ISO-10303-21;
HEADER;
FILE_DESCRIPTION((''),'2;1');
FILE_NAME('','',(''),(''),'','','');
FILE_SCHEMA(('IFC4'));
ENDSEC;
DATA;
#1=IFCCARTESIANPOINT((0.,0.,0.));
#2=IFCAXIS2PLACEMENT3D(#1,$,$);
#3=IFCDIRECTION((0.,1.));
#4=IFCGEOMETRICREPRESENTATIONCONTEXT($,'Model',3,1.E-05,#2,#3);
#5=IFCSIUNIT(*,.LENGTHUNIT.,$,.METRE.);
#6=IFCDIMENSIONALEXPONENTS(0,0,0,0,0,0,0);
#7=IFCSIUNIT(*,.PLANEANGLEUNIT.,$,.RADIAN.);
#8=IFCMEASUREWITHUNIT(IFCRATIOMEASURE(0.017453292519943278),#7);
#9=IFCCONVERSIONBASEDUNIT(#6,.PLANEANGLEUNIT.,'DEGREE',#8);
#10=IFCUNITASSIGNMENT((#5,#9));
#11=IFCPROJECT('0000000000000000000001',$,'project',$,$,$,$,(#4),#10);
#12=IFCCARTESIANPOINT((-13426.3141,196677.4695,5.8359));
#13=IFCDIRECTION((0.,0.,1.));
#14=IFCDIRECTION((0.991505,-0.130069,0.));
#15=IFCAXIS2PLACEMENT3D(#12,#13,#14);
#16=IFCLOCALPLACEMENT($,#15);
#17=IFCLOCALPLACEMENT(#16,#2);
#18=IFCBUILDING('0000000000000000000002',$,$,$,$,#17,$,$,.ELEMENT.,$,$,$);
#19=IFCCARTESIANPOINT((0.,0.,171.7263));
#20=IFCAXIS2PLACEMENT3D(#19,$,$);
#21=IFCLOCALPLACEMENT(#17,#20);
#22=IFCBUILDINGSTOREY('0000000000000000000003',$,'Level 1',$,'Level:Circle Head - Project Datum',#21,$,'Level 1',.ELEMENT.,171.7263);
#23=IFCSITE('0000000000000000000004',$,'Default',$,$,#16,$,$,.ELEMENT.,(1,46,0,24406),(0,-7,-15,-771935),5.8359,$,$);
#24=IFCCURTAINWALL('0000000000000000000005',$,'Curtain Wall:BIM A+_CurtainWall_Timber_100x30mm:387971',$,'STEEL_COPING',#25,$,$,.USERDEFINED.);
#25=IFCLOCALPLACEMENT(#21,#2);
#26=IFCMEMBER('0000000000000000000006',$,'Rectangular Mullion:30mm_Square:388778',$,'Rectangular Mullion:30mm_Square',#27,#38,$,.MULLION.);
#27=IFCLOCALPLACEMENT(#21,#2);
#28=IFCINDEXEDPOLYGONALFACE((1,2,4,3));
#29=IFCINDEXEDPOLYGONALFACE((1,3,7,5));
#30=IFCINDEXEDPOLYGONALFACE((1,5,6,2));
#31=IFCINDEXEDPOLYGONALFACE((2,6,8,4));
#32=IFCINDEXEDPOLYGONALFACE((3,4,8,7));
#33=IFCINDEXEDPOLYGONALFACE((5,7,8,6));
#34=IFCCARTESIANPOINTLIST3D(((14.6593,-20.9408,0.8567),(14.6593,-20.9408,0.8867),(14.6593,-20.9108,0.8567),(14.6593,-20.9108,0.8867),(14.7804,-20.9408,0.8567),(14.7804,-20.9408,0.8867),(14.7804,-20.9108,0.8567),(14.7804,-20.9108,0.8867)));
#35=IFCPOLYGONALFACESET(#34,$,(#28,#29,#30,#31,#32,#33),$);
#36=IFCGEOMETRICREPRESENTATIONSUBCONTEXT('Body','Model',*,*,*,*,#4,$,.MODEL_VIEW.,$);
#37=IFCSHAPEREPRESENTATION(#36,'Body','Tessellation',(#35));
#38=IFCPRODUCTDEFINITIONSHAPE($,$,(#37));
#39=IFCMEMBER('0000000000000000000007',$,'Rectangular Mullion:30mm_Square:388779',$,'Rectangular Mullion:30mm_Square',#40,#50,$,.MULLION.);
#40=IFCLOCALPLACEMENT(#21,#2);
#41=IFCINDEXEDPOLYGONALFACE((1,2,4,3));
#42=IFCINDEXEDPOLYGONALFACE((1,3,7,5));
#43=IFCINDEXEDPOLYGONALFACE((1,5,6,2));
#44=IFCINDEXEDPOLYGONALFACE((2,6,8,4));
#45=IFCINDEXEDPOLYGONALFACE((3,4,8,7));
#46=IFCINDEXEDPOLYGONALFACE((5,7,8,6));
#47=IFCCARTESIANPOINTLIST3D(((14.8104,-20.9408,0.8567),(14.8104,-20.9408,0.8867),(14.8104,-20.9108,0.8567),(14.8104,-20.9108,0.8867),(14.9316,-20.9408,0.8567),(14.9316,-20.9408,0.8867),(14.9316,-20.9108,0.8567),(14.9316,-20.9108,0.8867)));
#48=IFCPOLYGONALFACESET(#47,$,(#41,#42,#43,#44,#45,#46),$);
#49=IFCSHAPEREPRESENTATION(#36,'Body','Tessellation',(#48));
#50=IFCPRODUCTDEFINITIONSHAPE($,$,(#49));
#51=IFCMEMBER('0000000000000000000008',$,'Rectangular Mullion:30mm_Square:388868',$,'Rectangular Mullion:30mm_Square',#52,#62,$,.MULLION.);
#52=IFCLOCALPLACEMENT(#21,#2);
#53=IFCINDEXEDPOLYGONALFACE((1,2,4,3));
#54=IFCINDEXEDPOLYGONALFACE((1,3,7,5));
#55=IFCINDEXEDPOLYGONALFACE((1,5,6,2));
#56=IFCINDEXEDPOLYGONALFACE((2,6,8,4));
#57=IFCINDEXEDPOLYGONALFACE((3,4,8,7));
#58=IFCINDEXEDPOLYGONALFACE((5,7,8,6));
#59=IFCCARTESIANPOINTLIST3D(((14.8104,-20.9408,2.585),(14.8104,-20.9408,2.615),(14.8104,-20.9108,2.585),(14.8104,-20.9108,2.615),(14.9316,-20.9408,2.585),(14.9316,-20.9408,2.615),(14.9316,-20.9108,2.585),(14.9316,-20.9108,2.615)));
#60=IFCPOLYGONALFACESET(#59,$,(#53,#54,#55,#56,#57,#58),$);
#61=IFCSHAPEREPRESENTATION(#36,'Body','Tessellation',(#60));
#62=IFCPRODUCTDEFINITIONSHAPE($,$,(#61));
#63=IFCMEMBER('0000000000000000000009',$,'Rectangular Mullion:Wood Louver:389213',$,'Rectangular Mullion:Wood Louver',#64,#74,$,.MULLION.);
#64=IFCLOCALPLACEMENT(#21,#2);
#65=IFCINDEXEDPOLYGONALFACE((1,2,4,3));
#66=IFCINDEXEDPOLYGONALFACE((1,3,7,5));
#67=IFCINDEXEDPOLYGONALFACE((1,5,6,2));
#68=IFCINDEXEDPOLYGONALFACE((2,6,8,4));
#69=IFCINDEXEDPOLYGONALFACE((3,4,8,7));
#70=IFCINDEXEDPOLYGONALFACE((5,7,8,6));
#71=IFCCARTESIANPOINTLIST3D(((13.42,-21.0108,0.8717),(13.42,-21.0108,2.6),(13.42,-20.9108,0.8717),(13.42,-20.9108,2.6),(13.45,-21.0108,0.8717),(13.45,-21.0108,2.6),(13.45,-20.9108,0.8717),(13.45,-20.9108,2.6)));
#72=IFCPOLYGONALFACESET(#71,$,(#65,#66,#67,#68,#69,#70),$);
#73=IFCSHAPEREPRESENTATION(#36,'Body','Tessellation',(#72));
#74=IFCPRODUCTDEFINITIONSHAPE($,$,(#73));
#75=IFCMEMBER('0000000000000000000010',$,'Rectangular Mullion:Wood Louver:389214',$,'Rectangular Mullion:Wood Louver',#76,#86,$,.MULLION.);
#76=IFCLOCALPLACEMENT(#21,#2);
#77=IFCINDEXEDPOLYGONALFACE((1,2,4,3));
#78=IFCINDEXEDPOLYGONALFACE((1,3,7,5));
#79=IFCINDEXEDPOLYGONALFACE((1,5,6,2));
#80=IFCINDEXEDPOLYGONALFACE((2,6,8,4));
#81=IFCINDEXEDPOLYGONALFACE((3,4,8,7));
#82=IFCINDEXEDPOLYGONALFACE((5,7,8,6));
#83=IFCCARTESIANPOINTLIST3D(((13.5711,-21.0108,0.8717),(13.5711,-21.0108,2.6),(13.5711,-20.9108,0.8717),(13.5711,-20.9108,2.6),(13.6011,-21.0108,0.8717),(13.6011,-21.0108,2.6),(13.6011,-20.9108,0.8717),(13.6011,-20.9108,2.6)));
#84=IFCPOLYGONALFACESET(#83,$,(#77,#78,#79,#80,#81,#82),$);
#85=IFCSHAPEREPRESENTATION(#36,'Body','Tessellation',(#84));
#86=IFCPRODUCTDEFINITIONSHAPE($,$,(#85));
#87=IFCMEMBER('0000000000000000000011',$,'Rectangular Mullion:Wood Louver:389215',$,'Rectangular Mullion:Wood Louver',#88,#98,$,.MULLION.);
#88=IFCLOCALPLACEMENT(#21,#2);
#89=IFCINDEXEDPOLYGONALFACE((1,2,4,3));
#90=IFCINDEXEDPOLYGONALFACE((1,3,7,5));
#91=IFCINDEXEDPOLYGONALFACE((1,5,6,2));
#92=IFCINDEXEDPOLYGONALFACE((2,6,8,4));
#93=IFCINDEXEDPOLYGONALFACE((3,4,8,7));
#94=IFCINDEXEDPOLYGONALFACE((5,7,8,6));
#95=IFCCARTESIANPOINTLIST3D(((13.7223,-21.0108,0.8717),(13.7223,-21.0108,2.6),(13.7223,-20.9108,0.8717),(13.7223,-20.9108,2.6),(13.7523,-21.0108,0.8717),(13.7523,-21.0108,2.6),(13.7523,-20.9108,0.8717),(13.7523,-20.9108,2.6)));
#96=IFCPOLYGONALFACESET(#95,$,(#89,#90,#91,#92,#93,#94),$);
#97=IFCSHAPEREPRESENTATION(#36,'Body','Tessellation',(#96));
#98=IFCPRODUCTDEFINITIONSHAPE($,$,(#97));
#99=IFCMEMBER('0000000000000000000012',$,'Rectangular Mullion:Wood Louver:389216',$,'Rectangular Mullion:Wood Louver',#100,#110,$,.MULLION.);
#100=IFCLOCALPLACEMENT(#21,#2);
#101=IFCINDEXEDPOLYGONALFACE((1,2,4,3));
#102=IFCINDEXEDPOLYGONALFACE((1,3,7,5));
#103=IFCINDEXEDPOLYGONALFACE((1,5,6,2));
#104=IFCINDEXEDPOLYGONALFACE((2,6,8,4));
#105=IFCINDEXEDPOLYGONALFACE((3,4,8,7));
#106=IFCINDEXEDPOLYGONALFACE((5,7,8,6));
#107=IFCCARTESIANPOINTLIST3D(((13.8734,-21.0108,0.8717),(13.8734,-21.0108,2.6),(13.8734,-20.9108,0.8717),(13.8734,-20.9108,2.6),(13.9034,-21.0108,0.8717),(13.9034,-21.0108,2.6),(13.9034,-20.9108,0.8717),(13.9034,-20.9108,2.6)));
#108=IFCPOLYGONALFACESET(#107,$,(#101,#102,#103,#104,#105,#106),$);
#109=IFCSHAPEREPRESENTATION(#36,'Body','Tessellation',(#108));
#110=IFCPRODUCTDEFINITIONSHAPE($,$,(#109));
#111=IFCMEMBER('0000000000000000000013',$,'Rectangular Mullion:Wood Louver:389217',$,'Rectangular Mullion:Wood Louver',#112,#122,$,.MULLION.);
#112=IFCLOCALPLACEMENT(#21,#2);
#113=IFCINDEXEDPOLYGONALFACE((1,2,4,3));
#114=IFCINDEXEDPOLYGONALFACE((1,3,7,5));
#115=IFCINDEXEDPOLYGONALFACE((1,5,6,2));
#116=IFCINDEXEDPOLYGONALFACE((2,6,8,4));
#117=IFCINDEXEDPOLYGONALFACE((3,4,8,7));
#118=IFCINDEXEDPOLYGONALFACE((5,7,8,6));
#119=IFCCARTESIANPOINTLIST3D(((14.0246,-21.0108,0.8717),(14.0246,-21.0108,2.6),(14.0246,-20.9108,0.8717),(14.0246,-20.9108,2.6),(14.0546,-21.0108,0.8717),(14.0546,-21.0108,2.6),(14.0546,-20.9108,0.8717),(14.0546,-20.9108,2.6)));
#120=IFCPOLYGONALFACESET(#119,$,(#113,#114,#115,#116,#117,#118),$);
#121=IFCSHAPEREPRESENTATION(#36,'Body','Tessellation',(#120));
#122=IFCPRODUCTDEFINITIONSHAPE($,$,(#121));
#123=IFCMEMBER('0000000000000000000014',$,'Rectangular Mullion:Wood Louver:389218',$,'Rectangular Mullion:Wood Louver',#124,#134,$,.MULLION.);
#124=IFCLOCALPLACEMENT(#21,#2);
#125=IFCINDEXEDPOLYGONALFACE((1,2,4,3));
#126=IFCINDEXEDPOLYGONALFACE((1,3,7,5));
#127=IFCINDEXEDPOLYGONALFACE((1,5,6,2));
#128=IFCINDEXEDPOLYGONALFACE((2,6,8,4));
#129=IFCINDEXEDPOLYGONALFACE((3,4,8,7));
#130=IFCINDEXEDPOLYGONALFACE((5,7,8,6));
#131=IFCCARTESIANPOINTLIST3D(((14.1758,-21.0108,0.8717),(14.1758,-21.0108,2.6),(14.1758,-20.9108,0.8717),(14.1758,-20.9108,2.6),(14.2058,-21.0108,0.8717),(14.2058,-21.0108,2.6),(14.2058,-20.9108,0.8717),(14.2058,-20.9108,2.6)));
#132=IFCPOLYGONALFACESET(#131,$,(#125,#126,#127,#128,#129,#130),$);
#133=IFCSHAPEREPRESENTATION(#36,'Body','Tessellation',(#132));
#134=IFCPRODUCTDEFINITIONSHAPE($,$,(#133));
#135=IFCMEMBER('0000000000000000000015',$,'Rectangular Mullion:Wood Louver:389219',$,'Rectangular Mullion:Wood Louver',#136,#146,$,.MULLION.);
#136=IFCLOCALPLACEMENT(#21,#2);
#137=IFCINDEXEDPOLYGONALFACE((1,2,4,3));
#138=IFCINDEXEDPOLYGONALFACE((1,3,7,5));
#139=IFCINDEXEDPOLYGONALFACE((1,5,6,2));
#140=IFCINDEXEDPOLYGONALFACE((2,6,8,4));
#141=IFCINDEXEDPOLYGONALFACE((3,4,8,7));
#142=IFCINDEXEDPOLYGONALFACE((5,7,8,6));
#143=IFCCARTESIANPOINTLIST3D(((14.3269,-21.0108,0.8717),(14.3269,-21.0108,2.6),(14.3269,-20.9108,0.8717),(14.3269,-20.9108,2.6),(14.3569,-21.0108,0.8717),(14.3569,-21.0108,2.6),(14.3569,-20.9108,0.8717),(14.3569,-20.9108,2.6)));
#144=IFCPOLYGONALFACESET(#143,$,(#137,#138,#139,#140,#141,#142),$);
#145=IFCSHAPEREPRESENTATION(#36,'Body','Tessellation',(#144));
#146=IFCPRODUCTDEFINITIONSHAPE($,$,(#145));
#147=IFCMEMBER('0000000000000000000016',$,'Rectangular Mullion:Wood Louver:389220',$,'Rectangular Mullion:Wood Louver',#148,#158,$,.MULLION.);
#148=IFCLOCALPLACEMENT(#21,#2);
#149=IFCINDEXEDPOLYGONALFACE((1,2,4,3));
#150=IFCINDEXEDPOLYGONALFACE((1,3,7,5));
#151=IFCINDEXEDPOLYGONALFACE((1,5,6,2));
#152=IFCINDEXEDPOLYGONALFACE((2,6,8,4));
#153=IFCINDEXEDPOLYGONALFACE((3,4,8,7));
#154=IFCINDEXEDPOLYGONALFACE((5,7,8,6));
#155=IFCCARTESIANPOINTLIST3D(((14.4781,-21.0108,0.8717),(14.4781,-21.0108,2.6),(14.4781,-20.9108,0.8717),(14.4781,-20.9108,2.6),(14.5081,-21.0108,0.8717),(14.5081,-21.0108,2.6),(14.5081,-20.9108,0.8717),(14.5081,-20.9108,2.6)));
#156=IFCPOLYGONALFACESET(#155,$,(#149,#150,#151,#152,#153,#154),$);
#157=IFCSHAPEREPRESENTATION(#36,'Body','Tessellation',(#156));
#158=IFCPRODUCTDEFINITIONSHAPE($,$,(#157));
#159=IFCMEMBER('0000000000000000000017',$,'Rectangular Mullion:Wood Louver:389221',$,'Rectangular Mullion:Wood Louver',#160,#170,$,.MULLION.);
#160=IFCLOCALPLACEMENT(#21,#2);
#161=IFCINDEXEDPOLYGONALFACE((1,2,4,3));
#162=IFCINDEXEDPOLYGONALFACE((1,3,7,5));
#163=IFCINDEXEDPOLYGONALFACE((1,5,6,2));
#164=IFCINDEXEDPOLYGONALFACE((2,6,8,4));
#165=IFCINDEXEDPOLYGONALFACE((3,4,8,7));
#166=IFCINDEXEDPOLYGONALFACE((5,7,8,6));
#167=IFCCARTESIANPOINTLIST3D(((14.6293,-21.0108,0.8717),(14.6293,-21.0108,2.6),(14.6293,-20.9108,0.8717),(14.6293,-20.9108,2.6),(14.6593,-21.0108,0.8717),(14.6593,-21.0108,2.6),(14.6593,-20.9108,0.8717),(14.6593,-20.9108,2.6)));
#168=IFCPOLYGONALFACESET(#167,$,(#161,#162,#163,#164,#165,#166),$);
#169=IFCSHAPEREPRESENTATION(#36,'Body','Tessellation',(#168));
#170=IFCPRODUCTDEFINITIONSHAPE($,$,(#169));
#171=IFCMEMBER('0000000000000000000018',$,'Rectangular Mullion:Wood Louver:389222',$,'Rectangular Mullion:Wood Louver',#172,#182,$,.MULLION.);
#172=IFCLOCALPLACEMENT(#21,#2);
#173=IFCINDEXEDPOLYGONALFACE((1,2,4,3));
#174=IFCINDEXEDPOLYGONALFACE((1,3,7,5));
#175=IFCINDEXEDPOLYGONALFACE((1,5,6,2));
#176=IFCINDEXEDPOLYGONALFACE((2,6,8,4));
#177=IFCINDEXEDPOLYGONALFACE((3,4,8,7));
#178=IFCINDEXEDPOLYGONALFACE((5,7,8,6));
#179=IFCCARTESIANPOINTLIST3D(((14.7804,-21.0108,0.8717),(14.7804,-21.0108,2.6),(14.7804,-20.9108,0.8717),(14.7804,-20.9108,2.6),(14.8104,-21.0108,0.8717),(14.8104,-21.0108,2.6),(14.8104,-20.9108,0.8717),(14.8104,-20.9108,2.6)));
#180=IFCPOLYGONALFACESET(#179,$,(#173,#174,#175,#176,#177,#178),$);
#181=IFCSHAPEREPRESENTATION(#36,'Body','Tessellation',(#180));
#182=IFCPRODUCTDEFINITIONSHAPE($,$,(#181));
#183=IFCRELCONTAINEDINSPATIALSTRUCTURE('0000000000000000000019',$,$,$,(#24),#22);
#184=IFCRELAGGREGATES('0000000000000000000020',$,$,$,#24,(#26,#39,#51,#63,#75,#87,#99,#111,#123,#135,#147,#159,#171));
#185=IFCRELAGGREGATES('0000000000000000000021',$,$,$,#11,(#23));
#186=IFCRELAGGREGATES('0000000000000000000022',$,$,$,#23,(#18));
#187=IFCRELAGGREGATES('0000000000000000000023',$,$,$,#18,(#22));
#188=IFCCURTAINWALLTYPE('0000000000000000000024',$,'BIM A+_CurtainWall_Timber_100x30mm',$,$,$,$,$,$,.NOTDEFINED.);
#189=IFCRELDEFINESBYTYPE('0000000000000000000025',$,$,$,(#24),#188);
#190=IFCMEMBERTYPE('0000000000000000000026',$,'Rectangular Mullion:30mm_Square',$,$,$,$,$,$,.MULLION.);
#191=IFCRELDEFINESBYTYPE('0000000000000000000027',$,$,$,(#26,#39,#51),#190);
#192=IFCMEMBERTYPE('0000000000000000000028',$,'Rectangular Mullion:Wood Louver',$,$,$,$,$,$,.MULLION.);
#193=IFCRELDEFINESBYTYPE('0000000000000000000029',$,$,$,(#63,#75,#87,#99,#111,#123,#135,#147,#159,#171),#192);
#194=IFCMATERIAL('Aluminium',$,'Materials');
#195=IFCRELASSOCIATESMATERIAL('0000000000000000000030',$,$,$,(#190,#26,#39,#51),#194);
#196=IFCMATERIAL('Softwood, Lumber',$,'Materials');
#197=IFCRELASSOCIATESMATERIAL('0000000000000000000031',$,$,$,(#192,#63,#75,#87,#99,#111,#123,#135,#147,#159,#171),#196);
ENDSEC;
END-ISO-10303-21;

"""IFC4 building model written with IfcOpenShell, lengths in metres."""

from ifc_helpers import new_model, entity, si_unit, converted_unit, direction, frame, origin, place, context, subcontext, project, spatial, indexed_curve, outline, extrude, source, transform, mapped, material, type_object, type_shapes, element, aggregate, save


model = new_model("IFC4")

# Units and contexts
model_context = context("Model", 3, precision=1e-05, world=origin(), true_north=direction((0.0, 1.0)))
body_context = subcontext(model_context, "Body", "Model", "MODEL_VIEW")
ifc_project = project(units=[si_unit("LENGTHUNIT", "METRE"), converted_unit("PLANEANGLEUNIT", "DEGREE", entity("IfcRatioMeasure", 0.017453292519943278), si_unit("PLANEANGLEUNIT", "RADIAN"), dimensions=[0, 0, 0, 0, 0, 0, 0])], contexts=[model_context])

# Site, building, storey
site_placement = place(None, frame((-13426.3141, 196677.4695, 5.8359), z_axis=(0.0, 0.0, 1.0), x_axis=(0.991505, -0.130069, 0.0)))
site = spatial("IfcSite", under=ifc_project, at=site_placement, Name="Default", CompositionType="ELEMENT", RefLatitude=(1, 46, 0, 24406), RefLongitude=(0, -7, -15, -771935), RefElevation=5.8359)
building_placement = place(site_placement, origin())
building = spatial("IfcBuilding", under=site, at=building_placement, CompositionType="ELEMENT")
storey_placement = place(building_placement, frame((0.0, 0.0, 171.7263)))
storey = spatial("IfcBuildingStorey", under=building, at=storey_placement, Name="Level 1", ObjectType="Level:Circle Head - Project Datum", LongName="Level 1", CompositionType="ELEMENT", Elevation=171.7263)

# Curtain wall, members
ifc_material_1 = material(Name="Aluminium", Category="Materials")
curtain_wall_type_1 = type_object("IfcCurtainWallType", Name="BIM A+_CurtainWall_Timber_100x30mm", PredefinedType="NOTDEFINED")
curtain_wall_1_placement = place(storey_placement, frame((0.0, 0.0, -171.7263)))
curtain_wall_1 = element("IfcCurtainWall", 1, at=curtain_wall_1_placement, inside=storey, type_object=curtain_wall_type_1, Name="Curtain Wall:BIM A+_CurtainWall_Timber_100x30mm:387971", ObjectType="STEEL_COPING", PredefinedType="USERDEFINED")
member_type_1 = type_object("IfcMemberType", Name="Rectangular Mullion:30mm_Square", PredefinedType="MULLION", material=ifc_material_1)
shared_shape_1 = source(origin(), body_context, "Body", "SweptSolid", [
    extrude(outline(indexed_curve([(-0.015, -0.015), (0.015, -0.015), (0.015, 0.015), (-0.015, 0.015), (-0.015, -0.015)], self_intersect=False)), frame((0.0, 0.0, -0.1212), z_axis=(0.0, 0.0, 1.0), x_axis=(0.0, -1.0, 0.0)), (0.0, 0.0, 1.0), 0.1212),
])
type_shapes(member_type_1, [shared_shape_1])
member_1_placement = place(curtain_wall_1_placement, frame((14.7804, -20.9258, 172.598), z_axis=(1.0, 0.0, 0.0), x_axis=(0.0, 0.0, 1.0)))
member_1 = element("IfcMember", 2, at=member_1_placement, type_object=member_type_1, material=ifc_material_1, Name="Rectangular Mullion:30mm_Square:388778", ObjectType="Rectangular Mullion:30mm_Square", PredefinedType="MULLION", context=body_context, shape_type="MappedRepresentation", body=[
    mapped(shared_shape_1, transform((0.0, 0.0, 0.0), scale=1.0)),
])
member_2_placement = place(curtain_wall_1_placement, frame((14.9316, -20.9258, 172.598), z_axis=(1.0, 0.0, 0.0), x_axis=(0.0, 0.0, 1.0)))
member_2 = element("IfcMember", 3, at=member_2_placement, type_object=member_type_1, material=ifc_material_1, Name="Rectangular Mullion:30mm_Square:388779", ObjectType="Rectangular Mullion:30mm_Square", PredefinedType="MULLION", context=body_context, shape_type="MappedRepresentation", body=[
    mapped(shared_shape_1, transform((0.0, 0.0, 0.0), scale=1.0)),
])
member_3_placement = place(curtain_wall_1_placement, frame((14.9316, -20.9258, 174.3263), z_axis=(1.0, 0.0, 0.0), x_axis=(0.0, 0.0, 1.0)))
member_3 = element("IfcMember", 4, at=member_3_placement, type_object=member_type_1, material=ifc_material_1, Name="Rectangular Mullion:30mm_Square:388868", ObjectType="Rectangular Mullion:30mm_Square", PredefinedType="MULLION", context=body_context, shape_type="MappedRepresentation", body=[
    mapped(shared_shape_1, transform((0.0, 0.0, 0.0), scale=1.0)),
])
ifc_material_2 = material(Name="Softwood, Lumber", Category="Materials")
member_type_2 = type_object("IfcMemberType", Name="Rectangular Mullion:Wood Louver", PredefinedType="MULLION", material=ifc_material_2)
shared_shape_2 = source(origin(), body_context, "Body", "SweptSolid", [
    extrude(outline(indexed_curve([(-0.05, -0.015), (0.05, -0.015), (0.05, 0.015), (-0.05, 0.015), (-0.05, -0.015)], self_intersect=False)), frame((0.0, 0.035, -1.7283), z_axis=(0.0, 0.0, 1.0), x_axis=(0.0, -1.0, 0.0)), (0.0, 0.0, 1.0), 1.7283),
])
type_shapes(member_type_2, [shared_shape_2])
member_4_placement = place(curtain_wall_1_placement, frame((13.435, -20.9258, 172.598), z_axis=(0.0, 0.0, -1.0), x_axis=(1.0, 0.0, 0.0)))
member_4 = element("IfcMember", 5, at=member_4_placement, type_object=member_type_2, material=ifc_material_2, Name="Rectangular Mullion:Wood Louver:389213", ObjectType="Rectangular Mullion:Wood Louver", PredefinedType="MULLION", context=body_context, shape_type="MappedRepresentation", body=[
    mapped(shared_shape_2, transform((0.0, 0.0, 0.0), scale=1.0)),
])
member_5_placement = place(curtain_wall_1_placement, frame((13.5861, -20.9258, 172.598), z_axis=(0.0, 0.0, -1.0), x_axis=(1.0, 0.0, 0.0)))
member_5 = element("IfcMember", 6, at=member_5_placement, type_object=member_type_2, material=ifc_material_2, Name="Rectangular Mullion:Wood Louver:389214", ObjectType="Rectangular Mullion:Wood Louver", PredefinedType="MULLION", context=body_context, shape_type="MappedRepresentation", body=[
    mapped(shared_shape_2, transform((0.0, 0.0, 0.0), scale=1.0)),
])
member_6_placement = place(curtain_wall_1_placement, frame((13.7373, -20.9258, 172.598), z_axis=(0.0, 0.0, -1.0), x_axis=(1.0, 0.0, 0.0)))
member_6 = element("IfcMember", 7, at=member_6_placement, type_object=member_type_2, material=ifc_material_2, Name="Rectangular Mullion:Wood Louver:389215", ObjectType="Rectangular Mullion:Wood Louver", PredefinedType="MULLION", context=body_context, shape_type="MappedRepresentation", body=[
    mapped(shared_shape_2, transform((0.0, 0.0, 0.0), scale=1.0)),
])
member_7_placement = place(curtain_wall_1_placement, frame((13.8884, -20.9258, 172.598), z_axis=(0.0, 0.0, -1.0), x_axis=(1.0, 0.0, 0.0)))
member_7 = element("IfcMember", 8, at=member_7_placement, type_object=member_type_2, material=ifc_material_2, Name="Rectangular Mullion:Wood Louver:389216", ObjectType="Rectangular Mullion:Wood Louver", PredefinedType="MULLION", context=body_context, shape_type="MappedRepresentation", body=[
    mapped(shared_shape_2, transform((0.0, 0.0, 0.0), scale=1.0)),
])
member_8_placement = place(curtain_wall_1_placement, frame((14.0396, -20.9258, 172.598), z_axis=(0.0, 0.0, -1.0), x_axis=(1.0, 0.0, 0.0)))
member_8 = element("IfcMember", 9, at=member_8_placement, type_object=member_type_2, material=ifc_material_2, Name="Rectangular Mullion:Wood Louver:389217", ObjectType="Rectangular Mullion:Wood Louver", PredefinedType="MULLION", context=body_context, shape_type="MappedRepresentation", body=[
    mapped(shared_shape_2, transform((0.0, 0.0, 0.0), scale=1.0)),
])
member_9_placement = place(curtain_wall_1_placement, frame((14.1908, -20.9258, 172.598), z_axis=(0.0, 0.0, -1.0), x_axis=(1.0, 0.0, 0.0)))
member_9 = element("IfcMember", 10, at=member_9_placement, type_object=member_type_2, material=ifc_material_2, Name="Rectangular Mullion:Wood Louver:389218", ObjectType="Rectangular Mullion:Wood Louver", PredefinedType="MULLION", context=body_context, shape_type="MappedRepresentation", body=[
    mapped(shared_shape_2, transform((0.0, 0.0, 0.0), scale=1.0)),
])
member_10_placement = place(curtain_wall_1_placement, frame((14.3419, -20.9258, 172.598), z_axis=(0.0, 0.0, -1.0), x_axis=(1.0, 0.0, 0.0)))
member_10 = element("IfcMember", 11, at=member_10_placement, type_object=member_type_2, material=ifc_material_2, Name="Rectangular Mullion:Wood Louver:389219", ObjectType="Rectangular Mullion:Wood Louver", PredefinedType="MULLION", context=body_context, shape_type="MappedRepresentation", body=[
    mapped(shared_shape_2, transform((0.0, 0.0, 0.0), scale=1.0)),
])
member_11_placement = place(curtain_wall_1_placement, frame((14.4931, -20.9258, 172.598), z_axis=(0.0, 0.0, -1.0), x_axis=(1.0, 0.0, 0.0)))
member_11 = element("IfcMember", 12, at=member_11_placement, type_object=member_type_2, material=ifc_material_2, Name="Rectangular Mullion:Wood Louver:389220", ObjectType="Rectangular Mullion:Wood Louver", PredefinedType="MULLION", context=body_context, shape_type="MappedRepresentation", body=[
    mapped(shared_shape_2, transform((0.0, 0.0, 0.0), scale=1.0)),
])
member_12_placement = place(curtain_wall_1_placement, frame((14.6443, -20.9258, 172.598), z_axis=(0.0, 0.0, -1.0), x_axis=(1.0, 0.0, 0.0)))
member_12 = element("IfcMember", 13, at=member_12_placement, type_object=member_type_2, material=ifc_material_2, Name="Rectangular Mullion:Wood Louver:389221", ObjectType="Rectangular Mullion:Wood Louver", PredefinedType="MULLION", context=body_context, shape_type="MappedRepresentation", body=[
    mapped(shared_shape_2, transform((0.0, 0.0, 0.0), scale=1.0)),
])
member_13_placement = place(curtain_wall_1_placement, frame((14.7954, -20.9258, 172.598), z_axis=(0.0, 0.0, -1.0), x_axis=(1.0, 0.0, 0.0)))
member_13 = element("IfcMember", 14, at=member_13_placement, type_object=member_type_2, material=ifc_material_2, Name="Rectangular Mullion:Wood Louver:389222", ObjectType="Rectangular Mullion:Wood Louver", PredefinedType="MULLION", context=body_context, shape_type="MappedRepresentation", body=[
    mapped(shared_shape_2, transform((0.0, 0.0, 0.0), scale=1.0)),
])

aggregate(curtain_wall_1, [member_1, member_2, member_3, member_4, member_5, member_6, member_7, member_8, member_9, member_10, member_11, member_12, member_13])

save(model, "model.ifc")
